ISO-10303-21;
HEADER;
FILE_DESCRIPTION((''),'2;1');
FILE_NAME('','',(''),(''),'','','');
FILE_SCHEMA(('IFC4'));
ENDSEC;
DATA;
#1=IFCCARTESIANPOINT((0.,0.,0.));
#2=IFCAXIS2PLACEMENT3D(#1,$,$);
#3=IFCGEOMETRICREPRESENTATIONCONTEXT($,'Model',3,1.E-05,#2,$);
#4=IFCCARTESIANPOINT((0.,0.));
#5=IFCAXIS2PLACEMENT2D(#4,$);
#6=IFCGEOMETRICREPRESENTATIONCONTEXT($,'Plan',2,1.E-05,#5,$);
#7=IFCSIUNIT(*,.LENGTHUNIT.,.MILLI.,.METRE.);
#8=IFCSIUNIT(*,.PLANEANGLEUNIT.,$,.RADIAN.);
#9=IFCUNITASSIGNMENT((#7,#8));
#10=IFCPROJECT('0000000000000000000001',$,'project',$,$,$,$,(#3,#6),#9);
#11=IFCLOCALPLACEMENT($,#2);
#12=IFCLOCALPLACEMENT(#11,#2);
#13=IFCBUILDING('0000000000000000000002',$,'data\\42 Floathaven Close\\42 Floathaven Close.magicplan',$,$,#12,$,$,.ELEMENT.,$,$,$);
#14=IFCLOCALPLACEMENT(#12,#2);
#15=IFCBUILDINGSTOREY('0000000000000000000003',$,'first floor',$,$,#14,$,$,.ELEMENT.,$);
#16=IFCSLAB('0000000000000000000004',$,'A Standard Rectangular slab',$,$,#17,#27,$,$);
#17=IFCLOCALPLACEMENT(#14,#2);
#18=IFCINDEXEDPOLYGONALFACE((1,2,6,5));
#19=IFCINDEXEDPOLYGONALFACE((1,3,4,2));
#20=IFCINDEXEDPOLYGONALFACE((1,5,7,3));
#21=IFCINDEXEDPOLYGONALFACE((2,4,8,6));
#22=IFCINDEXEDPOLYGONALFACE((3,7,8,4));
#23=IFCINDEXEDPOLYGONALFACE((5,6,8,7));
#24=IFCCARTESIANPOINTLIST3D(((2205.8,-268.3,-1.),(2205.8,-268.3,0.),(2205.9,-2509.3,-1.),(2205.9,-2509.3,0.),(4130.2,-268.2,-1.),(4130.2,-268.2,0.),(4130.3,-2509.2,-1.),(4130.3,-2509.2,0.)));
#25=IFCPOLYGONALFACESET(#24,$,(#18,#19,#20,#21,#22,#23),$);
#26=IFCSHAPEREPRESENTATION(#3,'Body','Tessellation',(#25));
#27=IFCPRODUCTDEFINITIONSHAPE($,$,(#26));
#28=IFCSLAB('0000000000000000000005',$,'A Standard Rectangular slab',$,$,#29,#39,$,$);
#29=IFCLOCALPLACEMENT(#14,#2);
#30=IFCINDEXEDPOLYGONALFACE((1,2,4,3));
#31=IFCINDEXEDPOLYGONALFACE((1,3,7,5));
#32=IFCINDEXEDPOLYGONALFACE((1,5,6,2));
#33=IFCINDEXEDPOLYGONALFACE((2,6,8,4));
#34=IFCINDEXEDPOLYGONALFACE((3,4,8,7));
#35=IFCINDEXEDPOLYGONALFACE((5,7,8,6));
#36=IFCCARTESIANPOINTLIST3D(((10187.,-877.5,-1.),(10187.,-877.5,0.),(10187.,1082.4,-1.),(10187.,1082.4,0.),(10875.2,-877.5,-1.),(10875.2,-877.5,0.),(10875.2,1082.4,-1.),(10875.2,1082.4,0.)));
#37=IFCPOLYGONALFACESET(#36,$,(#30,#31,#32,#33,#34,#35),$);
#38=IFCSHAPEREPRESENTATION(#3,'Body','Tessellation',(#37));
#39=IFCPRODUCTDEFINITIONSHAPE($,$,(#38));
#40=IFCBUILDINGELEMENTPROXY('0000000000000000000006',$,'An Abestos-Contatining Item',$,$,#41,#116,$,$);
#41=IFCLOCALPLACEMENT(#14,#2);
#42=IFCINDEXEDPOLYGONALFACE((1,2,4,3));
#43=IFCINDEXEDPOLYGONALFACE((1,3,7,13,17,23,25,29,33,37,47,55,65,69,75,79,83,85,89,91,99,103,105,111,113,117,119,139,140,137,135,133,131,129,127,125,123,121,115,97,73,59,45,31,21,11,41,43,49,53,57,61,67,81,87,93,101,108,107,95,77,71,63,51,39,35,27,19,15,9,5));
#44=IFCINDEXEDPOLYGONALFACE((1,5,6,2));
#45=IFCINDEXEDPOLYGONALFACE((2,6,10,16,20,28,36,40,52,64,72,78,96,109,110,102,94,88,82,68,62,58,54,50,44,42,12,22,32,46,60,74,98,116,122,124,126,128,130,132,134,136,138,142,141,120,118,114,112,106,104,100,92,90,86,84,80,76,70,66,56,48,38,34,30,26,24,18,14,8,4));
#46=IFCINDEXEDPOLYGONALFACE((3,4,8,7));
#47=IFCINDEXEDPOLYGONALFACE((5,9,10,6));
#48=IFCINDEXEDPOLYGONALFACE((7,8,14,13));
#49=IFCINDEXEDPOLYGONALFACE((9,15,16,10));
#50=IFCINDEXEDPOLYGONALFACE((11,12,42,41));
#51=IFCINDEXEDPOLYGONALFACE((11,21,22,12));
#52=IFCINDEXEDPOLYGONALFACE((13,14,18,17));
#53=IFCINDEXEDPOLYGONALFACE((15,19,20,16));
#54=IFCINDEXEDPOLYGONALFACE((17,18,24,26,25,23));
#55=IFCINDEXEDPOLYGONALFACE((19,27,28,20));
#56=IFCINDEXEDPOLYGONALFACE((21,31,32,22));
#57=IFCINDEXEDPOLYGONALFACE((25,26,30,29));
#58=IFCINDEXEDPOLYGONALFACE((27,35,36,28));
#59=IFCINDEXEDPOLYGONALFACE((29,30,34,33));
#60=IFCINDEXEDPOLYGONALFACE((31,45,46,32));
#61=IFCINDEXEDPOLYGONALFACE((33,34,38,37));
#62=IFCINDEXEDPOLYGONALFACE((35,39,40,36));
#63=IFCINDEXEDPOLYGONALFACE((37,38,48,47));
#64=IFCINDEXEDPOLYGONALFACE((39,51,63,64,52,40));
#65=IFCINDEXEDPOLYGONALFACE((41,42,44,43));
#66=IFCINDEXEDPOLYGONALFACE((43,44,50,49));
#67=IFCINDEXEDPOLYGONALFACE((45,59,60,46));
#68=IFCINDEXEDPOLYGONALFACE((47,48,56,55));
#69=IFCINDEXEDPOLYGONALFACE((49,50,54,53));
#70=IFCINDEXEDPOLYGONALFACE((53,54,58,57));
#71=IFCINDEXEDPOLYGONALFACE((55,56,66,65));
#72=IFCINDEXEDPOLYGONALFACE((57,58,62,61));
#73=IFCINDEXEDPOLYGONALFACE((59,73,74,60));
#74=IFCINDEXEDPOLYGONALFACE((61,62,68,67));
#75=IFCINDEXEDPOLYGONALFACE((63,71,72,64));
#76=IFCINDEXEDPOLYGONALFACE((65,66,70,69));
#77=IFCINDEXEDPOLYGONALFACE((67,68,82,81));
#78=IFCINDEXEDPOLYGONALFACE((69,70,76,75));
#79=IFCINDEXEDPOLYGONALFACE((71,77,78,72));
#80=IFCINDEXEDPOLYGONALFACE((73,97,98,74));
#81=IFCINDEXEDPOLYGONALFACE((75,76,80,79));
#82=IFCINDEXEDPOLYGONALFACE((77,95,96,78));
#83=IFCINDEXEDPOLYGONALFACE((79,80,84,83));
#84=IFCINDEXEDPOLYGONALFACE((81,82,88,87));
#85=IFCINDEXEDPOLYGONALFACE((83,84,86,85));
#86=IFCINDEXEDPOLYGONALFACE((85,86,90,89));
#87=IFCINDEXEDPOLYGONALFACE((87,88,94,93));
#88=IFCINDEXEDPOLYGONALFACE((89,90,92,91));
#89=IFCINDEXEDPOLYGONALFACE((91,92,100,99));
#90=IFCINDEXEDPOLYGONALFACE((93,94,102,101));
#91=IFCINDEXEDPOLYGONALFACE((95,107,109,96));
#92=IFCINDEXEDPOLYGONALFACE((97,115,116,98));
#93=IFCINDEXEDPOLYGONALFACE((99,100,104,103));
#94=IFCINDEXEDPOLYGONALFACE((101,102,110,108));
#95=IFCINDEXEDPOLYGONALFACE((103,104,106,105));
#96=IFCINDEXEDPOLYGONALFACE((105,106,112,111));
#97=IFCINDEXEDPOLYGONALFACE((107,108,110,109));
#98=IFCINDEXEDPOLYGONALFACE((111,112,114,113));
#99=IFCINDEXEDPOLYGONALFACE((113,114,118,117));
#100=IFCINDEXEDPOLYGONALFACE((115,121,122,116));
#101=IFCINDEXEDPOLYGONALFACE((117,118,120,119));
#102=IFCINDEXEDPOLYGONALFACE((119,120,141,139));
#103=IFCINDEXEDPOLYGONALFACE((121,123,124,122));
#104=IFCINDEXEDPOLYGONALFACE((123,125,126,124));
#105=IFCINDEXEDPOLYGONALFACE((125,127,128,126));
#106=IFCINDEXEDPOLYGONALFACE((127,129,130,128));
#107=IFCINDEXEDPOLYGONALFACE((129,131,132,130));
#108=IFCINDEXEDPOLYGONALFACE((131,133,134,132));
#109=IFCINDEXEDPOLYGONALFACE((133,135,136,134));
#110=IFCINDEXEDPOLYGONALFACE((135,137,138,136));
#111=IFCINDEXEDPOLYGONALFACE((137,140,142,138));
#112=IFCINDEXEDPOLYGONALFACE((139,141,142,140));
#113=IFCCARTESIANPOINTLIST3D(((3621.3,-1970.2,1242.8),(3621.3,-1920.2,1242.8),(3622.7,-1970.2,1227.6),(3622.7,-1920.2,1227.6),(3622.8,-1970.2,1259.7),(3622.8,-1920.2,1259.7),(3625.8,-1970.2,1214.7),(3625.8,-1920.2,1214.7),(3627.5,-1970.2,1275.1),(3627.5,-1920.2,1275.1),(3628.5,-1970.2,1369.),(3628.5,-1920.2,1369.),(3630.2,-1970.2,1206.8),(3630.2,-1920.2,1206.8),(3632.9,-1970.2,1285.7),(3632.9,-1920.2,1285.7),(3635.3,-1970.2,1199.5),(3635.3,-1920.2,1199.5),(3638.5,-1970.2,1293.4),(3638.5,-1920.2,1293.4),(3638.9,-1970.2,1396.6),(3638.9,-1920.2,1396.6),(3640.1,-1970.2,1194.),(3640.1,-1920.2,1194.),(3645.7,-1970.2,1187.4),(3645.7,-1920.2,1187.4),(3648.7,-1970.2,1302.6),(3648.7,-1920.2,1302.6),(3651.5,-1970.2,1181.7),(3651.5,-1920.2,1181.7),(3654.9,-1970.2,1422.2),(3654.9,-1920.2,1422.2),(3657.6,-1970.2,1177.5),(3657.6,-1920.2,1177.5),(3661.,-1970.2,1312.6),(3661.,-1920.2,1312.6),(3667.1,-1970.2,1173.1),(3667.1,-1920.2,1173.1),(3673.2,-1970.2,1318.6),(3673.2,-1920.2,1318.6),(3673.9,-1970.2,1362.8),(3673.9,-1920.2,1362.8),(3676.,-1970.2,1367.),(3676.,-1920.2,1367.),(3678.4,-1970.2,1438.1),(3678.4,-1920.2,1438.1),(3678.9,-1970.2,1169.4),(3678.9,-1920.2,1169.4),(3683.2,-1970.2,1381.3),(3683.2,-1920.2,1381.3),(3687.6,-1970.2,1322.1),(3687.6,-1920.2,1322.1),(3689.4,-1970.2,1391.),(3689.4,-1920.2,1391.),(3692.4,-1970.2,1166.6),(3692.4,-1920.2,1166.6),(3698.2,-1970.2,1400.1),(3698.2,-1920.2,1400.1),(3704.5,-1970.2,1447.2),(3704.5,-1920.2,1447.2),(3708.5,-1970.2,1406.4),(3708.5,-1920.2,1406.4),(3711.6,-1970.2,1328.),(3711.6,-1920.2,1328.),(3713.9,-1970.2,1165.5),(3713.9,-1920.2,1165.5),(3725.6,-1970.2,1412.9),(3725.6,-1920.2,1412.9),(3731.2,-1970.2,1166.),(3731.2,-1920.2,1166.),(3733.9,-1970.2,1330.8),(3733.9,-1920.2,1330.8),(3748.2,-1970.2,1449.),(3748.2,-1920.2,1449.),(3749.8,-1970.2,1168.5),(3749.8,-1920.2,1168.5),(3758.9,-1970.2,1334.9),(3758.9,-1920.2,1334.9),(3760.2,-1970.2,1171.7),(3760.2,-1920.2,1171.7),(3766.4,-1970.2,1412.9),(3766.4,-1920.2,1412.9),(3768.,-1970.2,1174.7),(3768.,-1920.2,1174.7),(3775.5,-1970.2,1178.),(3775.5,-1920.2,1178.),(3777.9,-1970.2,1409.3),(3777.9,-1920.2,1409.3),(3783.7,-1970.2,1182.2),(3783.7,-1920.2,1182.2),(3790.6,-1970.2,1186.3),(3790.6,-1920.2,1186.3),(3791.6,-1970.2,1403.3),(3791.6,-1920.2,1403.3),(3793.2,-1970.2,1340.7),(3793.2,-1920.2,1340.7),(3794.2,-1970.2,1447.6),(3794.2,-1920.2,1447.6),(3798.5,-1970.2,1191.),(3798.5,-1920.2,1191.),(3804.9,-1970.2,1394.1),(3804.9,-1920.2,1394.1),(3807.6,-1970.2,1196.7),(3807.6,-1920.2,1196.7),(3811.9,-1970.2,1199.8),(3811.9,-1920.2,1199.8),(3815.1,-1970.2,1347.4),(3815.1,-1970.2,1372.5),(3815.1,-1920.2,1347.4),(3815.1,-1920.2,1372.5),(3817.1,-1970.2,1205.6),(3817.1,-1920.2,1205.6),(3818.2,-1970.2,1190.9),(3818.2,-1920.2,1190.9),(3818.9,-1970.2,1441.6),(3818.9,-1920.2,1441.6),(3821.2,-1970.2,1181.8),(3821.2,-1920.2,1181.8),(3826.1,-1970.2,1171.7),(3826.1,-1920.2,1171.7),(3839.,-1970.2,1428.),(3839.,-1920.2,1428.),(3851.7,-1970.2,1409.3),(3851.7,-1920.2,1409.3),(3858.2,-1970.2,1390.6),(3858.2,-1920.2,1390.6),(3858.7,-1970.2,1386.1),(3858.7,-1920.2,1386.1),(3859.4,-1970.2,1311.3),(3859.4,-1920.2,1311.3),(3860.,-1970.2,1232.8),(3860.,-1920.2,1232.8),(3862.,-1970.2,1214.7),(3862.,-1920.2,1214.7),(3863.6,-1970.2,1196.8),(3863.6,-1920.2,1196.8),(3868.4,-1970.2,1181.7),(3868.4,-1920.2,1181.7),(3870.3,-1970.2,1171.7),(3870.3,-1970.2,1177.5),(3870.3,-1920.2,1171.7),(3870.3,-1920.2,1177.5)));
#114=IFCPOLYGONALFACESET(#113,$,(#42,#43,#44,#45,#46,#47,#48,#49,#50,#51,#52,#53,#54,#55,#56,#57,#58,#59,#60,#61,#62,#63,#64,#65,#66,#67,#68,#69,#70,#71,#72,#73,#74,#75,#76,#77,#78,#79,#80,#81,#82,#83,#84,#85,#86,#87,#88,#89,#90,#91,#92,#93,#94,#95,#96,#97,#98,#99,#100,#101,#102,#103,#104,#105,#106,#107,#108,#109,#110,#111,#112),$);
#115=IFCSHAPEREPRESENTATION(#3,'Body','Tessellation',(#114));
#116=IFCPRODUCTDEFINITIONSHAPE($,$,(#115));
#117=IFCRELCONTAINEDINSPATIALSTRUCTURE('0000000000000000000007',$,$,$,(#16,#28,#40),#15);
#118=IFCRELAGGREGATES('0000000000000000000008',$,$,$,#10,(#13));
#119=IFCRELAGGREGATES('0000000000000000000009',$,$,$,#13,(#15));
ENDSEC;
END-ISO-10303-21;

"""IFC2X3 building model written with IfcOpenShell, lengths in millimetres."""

from ifc_helpers import new_model, si_unit, frame, origin, origin_2d, place, context, project, spatial, polyline, outline, extrude, element, save


model = new_model("IFC2X3")

# Units and contexts
model_context = context("Model", 3, precision=1e-05, world=origin())
plan_context = context("Plan", 2, precision=1e-05, world=origin_2d())
ifc_project = project(units=[si_unit("LENGTHUNIT", "METRE", prefix="MILLI"), si_unit("PLANEANGLEUNIT", "RADIAN")], contexts=[model_context, plan_context])

# Building, storey
placement_1 = place(None, origin())
building_placement = place(placement_1, origin())
building = spatial("IfcBuilding", under=ifc_project, at=building_placement, Name="data\\42 Floathaven Close\\42 Floathaven Close.magicplan", CompositionType="ELEMENT")
storey_placement = place(building_placement, origin())
storey = spatial("IfcBuildingStorey", under=building, at=storey_placement, Name="first floor", CompositionType="ELEMENT")

# Slabs
placement_2 = place(None, frame((3168.1, -1388.8, 0.0)))
slab_1_placement = place(placement_2, origin())
element("IfcSlab", 1, at=slab_1_placement, inside=storey, Name="A Standard Rectangular slab", context=model_context, shape_type="SweptSolid", body=[
    extrude(outline(polyline([(962.2, -1120.4, 0.0), (-962.1, -1120.5, 0.0), (-962.2, 1120.5, 0.0), (962.1, 1120.5, 0.0), (962.2, -1120.4, 0.0)]), kind="CURVE"), origin(), (0.0, 0.0, -1.0), 1.0),
])
placement_3 = place(None, frame((10531.1, 102.5, 0.0)))
slab_2_placement = place(placement_3, origin())
element("IfcSlab", 2, at=slab_2_placement, inside=storey, Name="A Standard Rectangular slab", context=model_context, shape_type="SweptSolid", body=[
    extrude(outline(polyline([(344.1, -979.9, 0.0), (-344.1, -979.9, 0.0), (-344.1, 979.9, 0.0), (344.1, 979.9, 0.0), (344.1, -979.9, 0.0)]), kind="CURVE"), origin(), (0.0, 0.0, -1.0), 1.0),
])

# Building element proxy
placement_4 = place(None, frame((3168.1, -1388.8, 0.0)))
proxy_1_placement = place(placement_4, frame((452.2, -531.4, 1165.0)))
element("IfcBuildingElementProxy", 3, at=proxy_1_placement, inside=storey, Name="An Abestos-Contatining Item", context=model_context, shape_type="SurfaceModel", body=[
    extrude(outline(polyline([(239.2, 0.0, 146.3), (239.7, 0.0, 67.8), (241.8, 0.0, 49.7), (243.3, 0.0, 31.9), (248.1, 0.0, 16.7), (250.0, 0.0, 12.5), (250.0, 0.0, 6.7), (205.8, 0.0, 6.7), (200.9, 0.0, 16.8), (197.9, 0.0, 25.9), (196.9, 0.0, 40.6), (191.6, 0.0, 34.8), (187.3, 0.0, 31.7), (178.2, 0.0, 26.0), (170.3, 0.0, 21.3), (163.4, 0.0, 17.2), (155.2, 0.0, 13.0), (147.8, 0.0, 9.7), (139.9, 0.0, 6.7), (129.5, 0.0, 3.5), (110.9, 0.0, 1.0), (93.6, 0.0, 0.5), (72.1, 0.0, 1.6), (58.6, 0.0, 4.4), (46.9, 0.0, 8.1), (37.3, 0.0, 12.5), (31.2, 0.0, 16.7), (25.4, 0.0, 22.4), (19.8, 0.0, 29.0), (15.1, 0.0, 34.5), (9.9, 0.0, 41.9), (5.5, 0.0, 49.7), (2.5, 0.0, 62.6), (1.0, 0.0, 77.8), (2.5, 0.0, 94.7), (7.2, 0.0, 110.1), (12.6, 0.0, 120.7), (18.2, 0.0, 128.4), (28.4, 0.0, 137.6), (40.7, 0.0, 147.6), (52.9, 0.0, 153.6), (67.3, 0.0, 157.1), (91.3, 0.0, 163.0), (113.7, 0.0, 165.8), (138.6, 0.0, 169.9), (172.9, 0.0, 175.7), (194.8, 0.0, 182.4), (194.8, 0.0, 207.5), (184.7, 0.0, 229.1), (171.3, 0.0, 238.3), (157.6, 0.0, 244.3), (146.2, 0.0, 247.9), (105.3, 0.0, 247.9), (88.3, 0.0, 241.4), (77.9, 0.0, 235.1), (69.1, 0.0, 226.0), (62.9, 0.0, 216.3), (55.7, 0.0, 202.0), (53.6, 0.0, 197.8), (8.2, 0.0, 204.0), (18.7, 0.0, 231.7), (34.6, 0.0, 257.2), (58.1, 0.0, 273.1), (84.2, 0.0, 282.2), (128.0, 0.0, 284.0), (173.9, 0.0, 282.6), (198.6, 0.0, 276.6), (218.8, 0.0, 263.1), (231.4, 0.0, 244.3), (238.0, 0.0, 225.6), (238.5, 0.0, 221.1)]), holes=[polyline([(193.0, 0.0, 144.2), (193.0, 0.0, 117.7), (190.5, 0.0, 97.8), (183.8, 0.0, 80.4), (174.2, 0.0, 64.5), (165.3, 0.0, 54.4), (152.5, 0.0, 47.3), (138.0, 0.0, 41.5), (124.6, 0.0, 37.8), (85.5, 0.0, 37.8), (75.0, 0.0, 41.4), (65.8, 0.0, 47.1), (57.8, 0.0, 55.4), (52.1, 0.0, 66.4), (49.5, 0.0, 74.4), (49.5, 0.0, 88.6), (55.3, 0.0, 100.7), (65.3, 0.0, 109.9), (81.0, 0.0, 119.8), (101.0, 0.0, 125.3), (119.9, 0.0, 128.5), (146.8, 0.0, 131.5), (165.0, 0.0, 134.9), (179.8, 0.0, 140.1), (193.0, 0.0, 144.2)])], kind="CURVE"), origin(), (0.0, -1.0, 0.0), 50.0),
])

save(model, "model.ifc")
